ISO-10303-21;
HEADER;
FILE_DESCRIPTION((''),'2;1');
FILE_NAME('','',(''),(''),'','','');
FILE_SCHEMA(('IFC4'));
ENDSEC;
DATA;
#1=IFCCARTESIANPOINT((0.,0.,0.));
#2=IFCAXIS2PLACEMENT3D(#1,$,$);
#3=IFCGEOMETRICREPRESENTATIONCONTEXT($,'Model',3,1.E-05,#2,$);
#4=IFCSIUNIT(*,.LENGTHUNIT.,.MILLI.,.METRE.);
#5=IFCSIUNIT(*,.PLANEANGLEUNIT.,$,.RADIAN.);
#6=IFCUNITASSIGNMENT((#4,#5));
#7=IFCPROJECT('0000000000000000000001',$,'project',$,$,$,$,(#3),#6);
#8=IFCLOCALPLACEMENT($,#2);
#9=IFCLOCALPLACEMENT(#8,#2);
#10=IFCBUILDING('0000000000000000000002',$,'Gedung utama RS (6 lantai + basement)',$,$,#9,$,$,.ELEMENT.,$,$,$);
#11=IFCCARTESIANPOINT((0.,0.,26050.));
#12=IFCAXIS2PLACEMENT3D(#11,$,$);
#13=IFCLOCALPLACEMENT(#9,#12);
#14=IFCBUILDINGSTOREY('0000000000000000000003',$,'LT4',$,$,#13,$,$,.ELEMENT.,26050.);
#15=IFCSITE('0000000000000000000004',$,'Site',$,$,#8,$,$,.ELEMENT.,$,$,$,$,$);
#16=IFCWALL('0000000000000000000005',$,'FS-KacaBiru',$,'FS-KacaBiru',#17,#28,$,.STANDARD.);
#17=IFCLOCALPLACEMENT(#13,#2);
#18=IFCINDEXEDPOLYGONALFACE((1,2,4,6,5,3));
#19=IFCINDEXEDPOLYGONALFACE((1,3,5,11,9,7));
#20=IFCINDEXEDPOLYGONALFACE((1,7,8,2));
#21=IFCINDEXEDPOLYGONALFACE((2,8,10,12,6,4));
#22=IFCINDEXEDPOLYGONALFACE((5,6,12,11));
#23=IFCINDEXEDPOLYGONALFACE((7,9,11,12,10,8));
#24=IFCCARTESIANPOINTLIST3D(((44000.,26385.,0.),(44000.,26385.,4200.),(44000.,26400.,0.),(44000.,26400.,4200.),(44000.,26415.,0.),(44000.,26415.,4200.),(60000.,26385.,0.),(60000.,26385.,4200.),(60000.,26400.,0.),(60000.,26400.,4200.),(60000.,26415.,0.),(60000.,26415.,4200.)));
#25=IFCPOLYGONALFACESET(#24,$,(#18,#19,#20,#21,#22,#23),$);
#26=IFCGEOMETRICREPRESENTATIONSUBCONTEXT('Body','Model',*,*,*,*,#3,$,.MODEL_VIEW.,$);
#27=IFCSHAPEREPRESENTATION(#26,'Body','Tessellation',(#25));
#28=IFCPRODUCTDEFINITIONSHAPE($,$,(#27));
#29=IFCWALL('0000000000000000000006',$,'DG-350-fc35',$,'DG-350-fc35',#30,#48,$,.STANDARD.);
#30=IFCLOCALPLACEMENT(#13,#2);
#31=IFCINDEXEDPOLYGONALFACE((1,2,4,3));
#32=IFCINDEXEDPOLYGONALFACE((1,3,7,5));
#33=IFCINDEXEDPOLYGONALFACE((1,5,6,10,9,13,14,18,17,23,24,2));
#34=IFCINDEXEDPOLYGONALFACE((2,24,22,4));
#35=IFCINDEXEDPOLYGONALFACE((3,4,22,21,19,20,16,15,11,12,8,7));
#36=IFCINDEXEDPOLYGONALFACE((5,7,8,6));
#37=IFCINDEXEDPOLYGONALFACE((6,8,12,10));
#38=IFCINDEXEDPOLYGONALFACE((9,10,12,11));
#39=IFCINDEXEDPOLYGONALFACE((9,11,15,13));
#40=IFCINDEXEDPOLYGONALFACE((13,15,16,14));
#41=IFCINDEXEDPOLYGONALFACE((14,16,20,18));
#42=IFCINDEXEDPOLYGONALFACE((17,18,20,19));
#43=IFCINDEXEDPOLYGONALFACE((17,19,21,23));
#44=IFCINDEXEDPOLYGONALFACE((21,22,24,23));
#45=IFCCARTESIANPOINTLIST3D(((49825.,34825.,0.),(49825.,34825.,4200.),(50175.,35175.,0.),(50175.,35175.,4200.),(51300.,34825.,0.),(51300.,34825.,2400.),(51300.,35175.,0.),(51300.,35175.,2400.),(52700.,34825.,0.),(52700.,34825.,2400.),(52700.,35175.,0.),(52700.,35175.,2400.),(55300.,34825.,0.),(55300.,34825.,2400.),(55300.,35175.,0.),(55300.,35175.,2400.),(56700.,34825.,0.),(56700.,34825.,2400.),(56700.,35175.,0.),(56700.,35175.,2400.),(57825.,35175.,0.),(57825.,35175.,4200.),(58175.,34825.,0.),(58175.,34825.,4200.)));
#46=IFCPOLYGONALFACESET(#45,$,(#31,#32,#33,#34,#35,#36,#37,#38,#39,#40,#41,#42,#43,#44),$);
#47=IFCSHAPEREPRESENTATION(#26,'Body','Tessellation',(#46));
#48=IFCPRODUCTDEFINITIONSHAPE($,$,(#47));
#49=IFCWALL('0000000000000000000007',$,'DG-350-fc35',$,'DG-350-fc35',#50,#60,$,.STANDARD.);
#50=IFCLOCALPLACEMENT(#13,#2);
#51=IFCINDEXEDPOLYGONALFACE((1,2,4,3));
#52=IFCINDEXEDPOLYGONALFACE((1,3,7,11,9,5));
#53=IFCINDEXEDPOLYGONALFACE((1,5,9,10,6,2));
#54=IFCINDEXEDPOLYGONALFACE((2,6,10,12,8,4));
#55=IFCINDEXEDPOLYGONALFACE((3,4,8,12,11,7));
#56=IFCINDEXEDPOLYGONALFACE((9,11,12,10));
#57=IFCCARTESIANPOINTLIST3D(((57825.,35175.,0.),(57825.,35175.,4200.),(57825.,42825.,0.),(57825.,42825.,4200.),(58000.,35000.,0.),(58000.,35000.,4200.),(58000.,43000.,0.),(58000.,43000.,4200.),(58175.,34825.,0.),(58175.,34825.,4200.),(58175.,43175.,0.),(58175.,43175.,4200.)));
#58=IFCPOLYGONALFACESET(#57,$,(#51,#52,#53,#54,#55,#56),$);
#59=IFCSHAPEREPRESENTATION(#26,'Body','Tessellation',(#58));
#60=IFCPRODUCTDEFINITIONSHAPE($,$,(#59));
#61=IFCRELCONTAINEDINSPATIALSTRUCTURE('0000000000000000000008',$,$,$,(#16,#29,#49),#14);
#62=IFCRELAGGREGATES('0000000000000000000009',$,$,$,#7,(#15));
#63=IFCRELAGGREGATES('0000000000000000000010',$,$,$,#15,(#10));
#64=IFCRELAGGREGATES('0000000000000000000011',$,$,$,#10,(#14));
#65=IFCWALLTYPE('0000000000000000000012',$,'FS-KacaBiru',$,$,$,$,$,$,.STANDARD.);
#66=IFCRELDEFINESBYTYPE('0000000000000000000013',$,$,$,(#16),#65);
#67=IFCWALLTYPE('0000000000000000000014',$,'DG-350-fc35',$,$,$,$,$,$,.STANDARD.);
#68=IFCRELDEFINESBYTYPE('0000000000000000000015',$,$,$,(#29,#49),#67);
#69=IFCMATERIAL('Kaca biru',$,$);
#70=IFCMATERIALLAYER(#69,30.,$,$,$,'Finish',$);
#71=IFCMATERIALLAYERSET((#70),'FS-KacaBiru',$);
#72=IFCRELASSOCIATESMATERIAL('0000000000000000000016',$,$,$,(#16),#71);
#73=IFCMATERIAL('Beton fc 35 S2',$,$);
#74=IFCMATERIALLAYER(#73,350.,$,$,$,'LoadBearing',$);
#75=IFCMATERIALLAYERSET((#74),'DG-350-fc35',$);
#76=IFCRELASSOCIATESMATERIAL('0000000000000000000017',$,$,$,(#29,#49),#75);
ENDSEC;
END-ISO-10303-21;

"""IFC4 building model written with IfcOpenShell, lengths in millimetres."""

from ifc_helpers import new_model, si_unit, frame, frame_2d, origin, place, context, subcontext, project, spatial, polyline, rectangle, outline, extrude, material, layer, layer_set, layer_usage, type_object, element, save


model = new_model("IFC4")

# Units and contexts
model_context = context("Model", 3, precision=1e-05, world=origin())
body_context = subcontext(model_context, "Body", "Model", "MODEL_VIEW")
ifc_project = project(units=[si_unit("LENGTHUNIT", "METRE", prefix="MILLI"), si_unit("PLANEANGLEUNIT", "RADIAN")], contexts=[model_context])

# Site, building, storey
site_placement = place(None, origin())
site = spatial("IfcSite", under=ifc_project, at=site_placement, Name="Site", CompositionType="ELEMENT")
building_placement = place(site_placement, origin())
building = spatial("IfcBuilding", under=site, at=building_placement, Name="Gedung utama RS (6 lantai + basement)", CompositionType="ELEMENT")
storey_placement = place(building_placement, frame((0.0, 0.0, 26050.0)))
storey = spatial("IfcBuildingStorey", under=building, at=storey_placement, Name="LT4", CompositionType="ELEMENT", Elevation=26050.0)

# Wall
ifc_material_1 = material(Name="Kaca biru")
ifc_layer_1 = layer(ifc_material_1, 30.0, Category="Finish")
ifc_layer_set_1 = layer_set([ifc_layer_1], Name="FS-KacaBiru")
ifc_layer_usage_1 = layer_usage(ifc_layer_set_1, "AXIS2", "NEGATIVE", 15.0)
wall_type_1 = type_object("IfcWallType", Name="FS-KacaBiru", PredefinedType="STANDARD")
wall_1_placement = place(storey_placement, frame((60000.0, 26400.0, 0.0), z_axis=(0.0, 0.0, 1.0), x_axis=(-1.0, 0.0, 0.0)))
element("IfcWall", 1, at=wall_1_placement, inside=storey, type_object=wall_type_1, material=ifc_layer_usage_1, Name="FS-KacaBiru", ObjectType="FS-KacaBiru", PredefinedType="STANDARD", context=body_context, shape_type="SweptSolid", body=[
    extrude(outline(polyline([(0.0, -15.0), (0.0, 0.0), (0.0, 15.0), (16000.0, 15.0), (16000.0, 0.0), (16000.0, -15.0), (0.0, -15.0)])), origin(), (0.0, 0.0, 1.0), 4200.0),
])

# Wall, openings
ifc_material_2 = material(Name="Beton fc 35 S2")
ifc_layer_2 = layer(ifc_material_2, 350.0, Category="LoadBearing")
ifc_layer_set_2 = layer_set([ifc_layer_2], Name="DG-350-fc35")
ifc_layer_usage_2 = layer_usage(ifc_layer_set_2, "AXIS2", "NEGATIVE", 175.0)
wall_type_2 = type_object("IfcWallType", Name="DG-350-fc35", PredefinedType="STANDARD")
wall_2_placement = place(storey_placement, frame((50000.0, 35000.0, 0.0), z_axis=(0.0, 0.0, 1.0), x_axis=(1.0, 0.0, 0.0)))
wall_2 = element("IfcWall", 2, at=wall_2_placement, inside=storey, type_object=wall_type_2, material=ifc_layer_usage_2, Name="DG-350-fc35", ObjectType="DG-350-fc35", PredefinedType="STANDARD", context=body_context, shape_type="SweptSolid", body=[
    extrude(outline(polyline([(-175.0, -175.0), (0.0, 0.0), (175.0, 175.0), (7825.0, 175.0), (8000.0, 0.0), (8175.0, -175.0), (-175.0, -175.0)])), origin(), (0.0, 0.0, 1.0), 4200.0),
])
opening_1_placement = place(wall_2_placement, frame((1300.0, 0.0, 0.0), z_axis=(0.0, 0.0, 1.0), x_axis=(1.0, 0.0, 0.0)))
element("IfcOpeningElement", 3, at=opening_1_placement, cuts=wall_2, PredefinedType="OPENING", context=body_context, shape_type="SweptSolid", body=[
    extrude(rectangle(XDim=1400.0, YDim=370.0, at=frame_2d((700.0, 0.0))), origin(), (0.0, 0.0, 1.0), 2400.0),
])
opening_2_placement = place(wall_2_placement, frame((5300.0, 0.0, 0.0), z_axis=(0.0, 0.0, 1.0), x_axis=(1.0, 0.0, 0.0)))
element("IfcOpeningElement", 4, at=opening_2_placement, cuts=wall_2, PredefinedType="OPENING", context=body_context, shape_type="SweptSolid", body=[
    extrude(rectangle(XDim=1400.0, YDim=370.0, at=frame_2d((700.0, 0.0))), origin(), (0.0, 0.0, 1.0), 2400.0),
])

# Wall
wall_3_placement = place(storey_placement, frame((58000.0, 35000.0, 0.0), z_axis=(0.0, 0.0, 1.0), x_axis=(0.0, 1.0, 0.0)))
element("IfcWall", 5, at=wall_3_placement, inside=storey, type_object=wall_type_2, material=ifc_layer_usage_2, Name="DG-350-fc35", ObjectType="DG-350-fc35", PredefinedType="STANDARD", context=body_context, shape_type="SweptSolid", body=[
    extrude(outline(polyline([(-175.0, -175.0), (0.0, 0.0), (175.0, 175.0), (7825.0, 175.0), (8000.0, 0.0), (8175.0, -175.0), (-175.0, -175.0)])), origin(), (0.0, 0.0, 1.0), 4200.0),
])

save(model, "model.ifc")
